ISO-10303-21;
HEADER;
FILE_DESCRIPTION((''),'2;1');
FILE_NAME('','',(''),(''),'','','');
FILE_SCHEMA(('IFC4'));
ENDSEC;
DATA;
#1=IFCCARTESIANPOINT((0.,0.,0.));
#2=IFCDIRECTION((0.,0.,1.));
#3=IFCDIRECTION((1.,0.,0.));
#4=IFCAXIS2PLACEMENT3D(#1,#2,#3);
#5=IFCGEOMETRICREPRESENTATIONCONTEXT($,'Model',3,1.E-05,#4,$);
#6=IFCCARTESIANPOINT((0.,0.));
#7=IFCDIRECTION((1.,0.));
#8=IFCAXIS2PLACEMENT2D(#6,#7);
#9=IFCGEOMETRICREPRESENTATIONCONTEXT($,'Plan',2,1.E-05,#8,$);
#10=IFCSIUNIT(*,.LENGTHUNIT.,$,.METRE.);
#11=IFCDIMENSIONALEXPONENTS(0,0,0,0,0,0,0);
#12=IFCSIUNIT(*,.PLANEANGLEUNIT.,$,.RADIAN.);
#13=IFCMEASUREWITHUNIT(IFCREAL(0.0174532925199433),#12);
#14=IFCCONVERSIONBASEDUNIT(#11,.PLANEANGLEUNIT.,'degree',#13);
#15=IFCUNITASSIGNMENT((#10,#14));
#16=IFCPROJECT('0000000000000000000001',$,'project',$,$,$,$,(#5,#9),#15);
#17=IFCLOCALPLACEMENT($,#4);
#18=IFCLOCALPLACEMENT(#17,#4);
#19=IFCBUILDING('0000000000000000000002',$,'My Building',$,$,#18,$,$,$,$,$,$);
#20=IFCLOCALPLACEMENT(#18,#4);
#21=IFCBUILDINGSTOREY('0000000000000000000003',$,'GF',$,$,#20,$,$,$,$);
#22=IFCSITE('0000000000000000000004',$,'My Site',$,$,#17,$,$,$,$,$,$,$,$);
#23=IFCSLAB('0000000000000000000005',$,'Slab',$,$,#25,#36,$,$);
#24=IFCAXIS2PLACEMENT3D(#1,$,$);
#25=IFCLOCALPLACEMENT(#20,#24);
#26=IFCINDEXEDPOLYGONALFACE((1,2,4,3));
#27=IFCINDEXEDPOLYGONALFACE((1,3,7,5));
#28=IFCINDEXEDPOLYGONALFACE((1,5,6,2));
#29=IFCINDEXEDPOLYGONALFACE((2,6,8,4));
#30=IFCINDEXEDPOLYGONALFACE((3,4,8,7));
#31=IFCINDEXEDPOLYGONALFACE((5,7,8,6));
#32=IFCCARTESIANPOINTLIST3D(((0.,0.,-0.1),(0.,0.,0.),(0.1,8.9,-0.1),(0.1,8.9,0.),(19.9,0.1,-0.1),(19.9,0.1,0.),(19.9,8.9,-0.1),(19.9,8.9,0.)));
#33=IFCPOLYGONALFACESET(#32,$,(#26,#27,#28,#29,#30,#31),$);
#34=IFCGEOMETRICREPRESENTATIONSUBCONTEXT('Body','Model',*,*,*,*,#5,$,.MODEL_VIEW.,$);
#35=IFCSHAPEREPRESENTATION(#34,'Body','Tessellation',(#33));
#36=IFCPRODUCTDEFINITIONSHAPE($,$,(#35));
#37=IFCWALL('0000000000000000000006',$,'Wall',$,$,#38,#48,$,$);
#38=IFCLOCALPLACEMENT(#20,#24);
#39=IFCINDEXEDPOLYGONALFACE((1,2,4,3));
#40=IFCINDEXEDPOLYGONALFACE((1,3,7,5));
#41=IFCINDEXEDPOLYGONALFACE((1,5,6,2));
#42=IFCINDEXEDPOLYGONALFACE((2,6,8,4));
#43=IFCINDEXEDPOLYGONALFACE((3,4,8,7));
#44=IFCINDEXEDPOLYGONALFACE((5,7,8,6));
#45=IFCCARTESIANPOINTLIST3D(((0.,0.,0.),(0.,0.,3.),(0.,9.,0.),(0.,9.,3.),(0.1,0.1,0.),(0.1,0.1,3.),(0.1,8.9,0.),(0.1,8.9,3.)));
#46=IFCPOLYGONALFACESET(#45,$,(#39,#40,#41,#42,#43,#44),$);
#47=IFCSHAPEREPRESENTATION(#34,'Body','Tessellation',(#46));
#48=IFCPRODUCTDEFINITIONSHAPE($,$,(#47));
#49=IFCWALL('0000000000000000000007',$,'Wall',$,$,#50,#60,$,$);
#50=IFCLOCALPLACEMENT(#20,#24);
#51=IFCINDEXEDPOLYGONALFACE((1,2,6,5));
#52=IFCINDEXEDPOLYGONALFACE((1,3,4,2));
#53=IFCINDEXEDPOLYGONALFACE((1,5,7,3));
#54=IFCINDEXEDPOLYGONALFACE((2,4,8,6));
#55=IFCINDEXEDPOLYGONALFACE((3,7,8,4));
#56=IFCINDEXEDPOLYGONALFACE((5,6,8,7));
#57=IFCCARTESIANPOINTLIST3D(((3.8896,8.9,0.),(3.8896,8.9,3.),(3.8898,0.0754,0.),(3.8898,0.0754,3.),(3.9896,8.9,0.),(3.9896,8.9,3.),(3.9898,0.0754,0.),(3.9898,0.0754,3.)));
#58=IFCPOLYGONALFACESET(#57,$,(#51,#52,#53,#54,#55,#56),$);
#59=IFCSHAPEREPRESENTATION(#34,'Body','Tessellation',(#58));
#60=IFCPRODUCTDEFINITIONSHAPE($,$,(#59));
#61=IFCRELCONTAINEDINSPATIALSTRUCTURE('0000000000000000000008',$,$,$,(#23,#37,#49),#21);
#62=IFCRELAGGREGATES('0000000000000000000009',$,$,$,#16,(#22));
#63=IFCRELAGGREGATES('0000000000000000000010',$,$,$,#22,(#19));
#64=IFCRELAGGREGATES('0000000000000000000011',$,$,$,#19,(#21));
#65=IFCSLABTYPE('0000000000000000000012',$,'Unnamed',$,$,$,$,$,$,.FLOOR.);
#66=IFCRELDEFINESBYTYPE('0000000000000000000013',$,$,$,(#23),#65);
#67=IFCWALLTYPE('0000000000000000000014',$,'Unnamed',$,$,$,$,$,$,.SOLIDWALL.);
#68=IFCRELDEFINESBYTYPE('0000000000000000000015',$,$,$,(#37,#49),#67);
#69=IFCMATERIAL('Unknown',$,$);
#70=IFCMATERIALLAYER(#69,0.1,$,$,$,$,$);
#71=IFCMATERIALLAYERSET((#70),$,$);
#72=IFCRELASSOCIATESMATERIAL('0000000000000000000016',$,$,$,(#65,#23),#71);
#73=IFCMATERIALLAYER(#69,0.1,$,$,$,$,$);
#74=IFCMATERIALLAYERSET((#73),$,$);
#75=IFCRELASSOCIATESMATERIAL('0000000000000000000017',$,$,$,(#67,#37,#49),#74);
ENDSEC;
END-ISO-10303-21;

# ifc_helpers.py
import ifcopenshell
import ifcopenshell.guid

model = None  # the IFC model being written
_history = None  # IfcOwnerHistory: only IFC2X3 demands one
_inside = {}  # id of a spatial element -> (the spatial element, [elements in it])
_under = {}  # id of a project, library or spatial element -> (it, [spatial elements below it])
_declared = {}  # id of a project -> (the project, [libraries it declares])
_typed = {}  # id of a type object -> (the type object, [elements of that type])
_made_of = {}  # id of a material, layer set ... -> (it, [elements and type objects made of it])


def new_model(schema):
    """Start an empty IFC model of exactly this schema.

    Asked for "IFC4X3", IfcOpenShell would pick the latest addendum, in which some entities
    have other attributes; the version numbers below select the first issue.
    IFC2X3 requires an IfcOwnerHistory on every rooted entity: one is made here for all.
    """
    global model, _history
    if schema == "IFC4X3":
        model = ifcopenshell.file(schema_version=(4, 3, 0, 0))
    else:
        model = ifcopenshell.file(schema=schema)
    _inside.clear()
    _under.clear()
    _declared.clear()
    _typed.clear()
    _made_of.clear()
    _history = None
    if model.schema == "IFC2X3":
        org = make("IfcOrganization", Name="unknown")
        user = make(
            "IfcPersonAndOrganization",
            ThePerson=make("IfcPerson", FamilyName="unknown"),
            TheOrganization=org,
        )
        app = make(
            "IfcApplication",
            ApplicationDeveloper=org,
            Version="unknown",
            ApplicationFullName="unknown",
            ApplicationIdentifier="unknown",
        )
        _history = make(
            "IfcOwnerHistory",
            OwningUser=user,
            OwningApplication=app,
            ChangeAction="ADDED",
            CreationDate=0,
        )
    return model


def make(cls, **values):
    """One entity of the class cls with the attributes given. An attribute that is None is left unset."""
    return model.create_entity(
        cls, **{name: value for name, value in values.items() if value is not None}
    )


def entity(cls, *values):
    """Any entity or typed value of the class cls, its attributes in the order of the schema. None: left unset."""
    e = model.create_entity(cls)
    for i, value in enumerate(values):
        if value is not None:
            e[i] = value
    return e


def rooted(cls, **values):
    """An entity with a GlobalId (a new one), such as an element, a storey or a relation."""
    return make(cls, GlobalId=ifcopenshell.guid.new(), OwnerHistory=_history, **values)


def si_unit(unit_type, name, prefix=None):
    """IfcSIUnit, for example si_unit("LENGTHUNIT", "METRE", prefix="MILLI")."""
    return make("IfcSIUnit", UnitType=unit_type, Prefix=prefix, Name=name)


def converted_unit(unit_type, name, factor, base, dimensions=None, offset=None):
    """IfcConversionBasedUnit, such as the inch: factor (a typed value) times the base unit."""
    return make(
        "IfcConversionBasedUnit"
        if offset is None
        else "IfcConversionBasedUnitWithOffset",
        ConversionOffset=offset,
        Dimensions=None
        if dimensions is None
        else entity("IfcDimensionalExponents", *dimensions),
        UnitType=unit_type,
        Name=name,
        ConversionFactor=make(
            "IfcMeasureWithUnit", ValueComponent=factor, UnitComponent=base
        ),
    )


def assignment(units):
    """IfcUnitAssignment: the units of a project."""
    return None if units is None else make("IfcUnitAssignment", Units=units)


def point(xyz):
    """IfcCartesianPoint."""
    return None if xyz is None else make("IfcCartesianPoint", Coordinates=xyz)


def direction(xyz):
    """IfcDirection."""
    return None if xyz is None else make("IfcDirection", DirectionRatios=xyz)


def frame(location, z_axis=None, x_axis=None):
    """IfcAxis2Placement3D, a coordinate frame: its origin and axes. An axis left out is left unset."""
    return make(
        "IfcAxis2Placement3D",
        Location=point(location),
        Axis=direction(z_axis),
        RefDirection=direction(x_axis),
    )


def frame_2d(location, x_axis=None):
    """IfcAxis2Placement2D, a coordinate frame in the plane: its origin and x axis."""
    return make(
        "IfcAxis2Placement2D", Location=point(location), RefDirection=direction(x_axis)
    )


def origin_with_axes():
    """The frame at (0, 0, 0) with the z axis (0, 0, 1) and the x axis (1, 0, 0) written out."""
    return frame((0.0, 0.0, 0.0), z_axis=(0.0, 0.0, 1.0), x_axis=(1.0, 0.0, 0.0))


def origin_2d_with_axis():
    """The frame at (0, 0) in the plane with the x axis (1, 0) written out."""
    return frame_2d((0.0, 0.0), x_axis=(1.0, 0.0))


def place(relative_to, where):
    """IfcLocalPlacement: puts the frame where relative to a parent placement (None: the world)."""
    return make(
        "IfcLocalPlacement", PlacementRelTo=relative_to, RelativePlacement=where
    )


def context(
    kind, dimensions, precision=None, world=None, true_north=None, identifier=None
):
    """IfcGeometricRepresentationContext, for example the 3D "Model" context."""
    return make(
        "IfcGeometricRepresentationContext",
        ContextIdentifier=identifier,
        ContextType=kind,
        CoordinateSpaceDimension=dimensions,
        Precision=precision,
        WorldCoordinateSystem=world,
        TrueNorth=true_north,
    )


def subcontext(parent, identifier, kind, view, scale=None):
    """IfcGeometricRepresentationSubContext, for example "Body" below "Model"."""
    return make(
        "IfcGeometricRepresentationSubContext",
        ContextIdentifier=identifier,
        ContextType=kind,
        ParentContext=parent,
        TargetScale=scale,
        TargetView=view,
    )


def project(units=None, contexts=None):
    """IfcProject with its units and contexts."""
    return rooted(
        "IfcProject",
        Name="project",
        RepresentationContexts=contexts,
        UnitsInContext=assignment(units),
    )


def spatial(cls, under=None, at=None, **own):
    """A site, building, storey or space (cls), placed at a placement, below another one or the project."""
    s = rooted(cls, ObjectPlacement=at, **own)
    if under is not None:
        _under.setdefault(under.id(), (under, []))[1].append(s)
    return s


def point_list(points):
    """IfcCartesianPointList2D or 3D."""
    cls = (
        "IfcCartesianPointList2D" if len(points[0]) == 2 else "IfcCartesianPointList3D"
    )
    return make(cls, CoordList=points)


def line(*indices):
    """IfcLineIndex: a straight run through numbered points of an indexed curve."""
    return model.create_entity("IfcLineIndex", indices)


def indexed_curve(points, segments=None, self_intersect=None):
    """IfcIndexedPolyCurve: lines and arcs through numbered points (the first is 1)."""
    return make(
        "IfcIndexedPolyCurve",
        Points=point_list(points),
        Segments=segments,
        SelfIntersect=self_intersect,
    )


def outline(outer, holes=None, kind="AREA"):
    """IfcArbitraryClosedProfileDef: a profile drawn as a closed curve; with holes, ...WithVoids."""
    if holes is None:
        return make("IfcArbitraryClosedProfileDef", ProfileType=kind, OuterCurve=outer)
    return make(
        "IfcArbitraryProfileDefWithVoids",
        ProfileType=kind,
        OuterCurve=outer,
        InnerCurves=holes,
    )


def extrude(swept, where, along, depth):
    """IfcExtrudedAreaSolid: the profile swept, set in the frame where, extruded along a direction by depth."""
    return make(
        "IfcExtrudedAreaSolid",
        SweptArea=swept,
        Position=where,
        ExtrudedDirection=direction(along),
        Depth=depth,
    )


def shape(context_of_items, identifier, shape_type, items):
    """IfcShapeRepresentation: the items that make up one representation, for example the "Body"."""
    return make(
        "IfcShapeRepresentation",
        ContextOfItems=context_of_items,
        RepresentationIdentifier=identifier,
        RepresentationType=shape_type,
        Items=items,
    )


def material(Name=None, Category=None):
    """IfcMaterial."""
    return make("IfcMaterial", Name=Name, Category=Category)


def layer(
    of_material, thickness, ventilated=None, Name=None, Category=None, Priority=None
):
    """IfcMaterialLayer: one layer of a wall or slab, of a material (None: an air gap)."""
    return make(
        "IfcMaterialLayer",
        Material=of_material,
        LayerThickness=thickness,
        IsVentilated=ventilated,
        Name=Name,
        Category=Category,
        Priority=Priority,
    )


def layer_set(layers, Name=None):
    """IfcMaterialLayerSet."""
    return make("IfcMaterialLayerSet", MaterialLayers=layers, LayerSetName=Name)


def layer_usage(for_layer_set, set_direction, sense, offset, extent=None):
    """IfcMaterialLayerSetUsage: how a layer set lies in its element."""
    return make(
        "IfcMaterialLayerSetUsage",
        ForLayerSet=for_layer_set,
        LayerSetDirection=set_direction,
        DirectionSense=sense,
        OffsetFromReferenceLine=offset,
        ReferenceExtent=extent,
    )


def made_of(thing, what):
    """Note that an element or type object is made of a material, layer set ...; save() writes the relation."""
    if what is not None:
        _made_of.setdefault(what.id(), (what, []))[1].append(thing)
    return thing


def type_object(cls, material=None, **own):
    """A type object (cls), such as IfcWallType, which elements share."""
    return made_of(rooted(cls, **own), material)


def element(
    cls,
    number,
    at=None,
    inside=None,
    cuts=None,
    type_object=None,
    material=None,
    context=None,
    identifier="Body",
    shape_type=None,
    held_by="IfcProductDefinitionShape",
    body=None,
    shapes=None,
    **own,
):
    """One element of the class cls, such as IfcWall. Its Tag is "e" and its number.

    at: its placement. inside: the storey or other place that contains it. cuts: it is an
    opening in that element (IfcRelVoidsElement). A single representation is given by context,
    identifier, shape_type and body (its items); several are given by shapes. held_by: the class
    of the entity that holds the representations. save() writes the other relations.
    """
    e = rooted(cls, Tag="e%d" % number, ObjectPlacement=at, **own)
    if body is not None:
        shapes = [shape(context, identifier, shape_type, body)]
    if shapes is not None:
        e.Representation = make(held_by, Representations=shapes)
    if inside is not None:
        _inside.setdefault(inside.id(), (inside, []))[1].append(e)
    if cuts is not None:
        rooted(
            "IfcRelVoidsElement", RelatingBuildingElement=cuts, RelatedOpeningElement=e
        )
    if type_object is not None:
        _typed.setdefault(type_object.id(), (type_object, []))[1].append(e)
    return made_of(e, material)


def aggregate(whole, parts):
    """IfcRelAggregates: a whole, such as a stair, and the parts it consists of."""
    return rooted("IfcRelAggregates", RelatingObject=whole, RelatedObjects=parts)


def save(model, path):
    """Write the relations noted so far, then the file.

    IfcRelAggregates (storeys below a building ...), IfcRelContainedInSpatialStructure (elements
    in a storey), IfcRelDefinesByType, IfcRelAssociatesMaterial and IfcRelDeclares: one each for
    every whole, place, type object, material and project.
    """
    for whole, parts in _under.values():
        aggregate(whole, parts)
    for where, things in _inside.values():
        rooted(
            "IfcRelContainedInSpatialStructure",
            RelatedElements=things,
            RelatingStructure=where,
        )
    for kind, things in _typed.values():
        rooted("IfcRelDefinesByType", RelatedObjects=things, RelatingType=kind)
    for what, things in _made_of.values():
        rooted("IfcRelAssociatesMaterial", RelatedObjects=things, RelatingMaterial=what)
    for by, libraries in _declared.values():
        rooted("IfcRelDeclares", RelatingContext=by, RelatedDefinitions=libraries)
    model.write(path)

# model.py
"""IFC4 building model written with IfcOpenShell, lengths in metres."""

from ifc_helpers import new_model, entity, si_unit, converted_unit, frame, origin_with_axes, origin_2d_with_axis, place, context, subcontext, project, spatial, line, indexed_curve, outline, extrude, material, layer, layer_set, layer_usage, type_object, element, save


model = new_model("IFC4")

# Units and contexts
model_context = context("Model", 3, precision=1e-05, world=origin_with_axes())
plan_context = context("Plan", 2, precision=1e-05, world=origin_2d_with_axis())
body_context_1 = subcontext(model_context, "Body", "Model", "MODEL_VIEW")
ifc_project = project(units=[si_unit("LENGTHUNIT", "METRE"), converted_unit("PLANEANGLEUNIT", "degree", entity("IfcReal", 0.0174532925199433), si_unit("PLANEANGLEUNIT", "RADIAN"), dimensions=[0, 0, 0, 0, 0, 0, 0])], contexts=[model_context, plan_context])

# Site, building, storey
site_placement = place(None, origin_with_axes())
site = spatial("IfcSite", under=ifc_project, at=site_placement, Name="My Site")
building_placement = place(site_placement, origin_with_axes())
building = spatial("IfcBuilding", under=site, at=building_placement, Name="My Building")
storey_placement = place(building_placement, origin_with_axes())
storey = spatial("IfcBuildingStorey", under=building, at=storey_placement, Name="GF")

# Slab
ifc_material = material(Name="Unknown")
ifc_layer_1 = layer(ifc_material, 0.1)
ifc_layer_set_1 = layer_set([ifc_layer_1])
ifc_layer_usage_1 = layer_usage(ifc_layer_set_1, "AXIS3", "POSITIVE", -0.1)
slab_type = type_object("IfcSlabType", Name="Unnamed", PredefinedType="FLOOR", material=ifc_layer_set_1)
slab_placement = place(storey_placement, frame((0.1, 8.9, 0.0), z_axis=(0.0, 0.0, 1.0), x_axis=(1.0, 0.0, 0.0)))
element("IfcSlab", 1, at=slab_placement, inside=storey, type_object=slab_type, material=ifc_layer_usage_1, Name="Slab", context=body_context_1, shape_type="SweptSolid", body=[
    extrude(outline(indexed_curve([(0.0, 0.0), (19.8, 0.0), (19.8, -8.8), (-0.1, -8.9), (0.0, 0.0)])), frame((0.0, 0.0, -0.1), z_axis=(0.0, 0.0, 1.0), x_axis=(1.0, 0.0, 0.0)), (0.0, 0.0, 1.0), 0.1),
])

# Shared definitions
ifc_layer_2 = layer(ifc_material, 0.1)
ifc_layer_set_2 = layer_set([ifc_layer_2])
wall_type = type_object("IfcWallType", Name="Unnamed", PredefinedType="SOLIDWALL", material=ifc_layer_set_2)

# Walls
ifc_layer_usage_2 = layer_usage(ifc_layer_set_2, "AXIS2", "POSITIVE", 0.0)
wall_1_placement = place(storey_placement, frame((0.0, 9.0, 0.0), z_axis=(0.0, 0.0, 1.0), x_axis=(0.0, -1.0, 0.0)))
element("IfcWall", 2, at=wall_1_placement, inside=storey, type_object=wall_type, material=ifc_layer_usage_2, Name="Wall", context=body_context_1, shape_type="SweptSolid", body=[
    extrude(outline(indexed_curve([(0.0, 0.0), (0.1, 0.1), (8.9, 0.1), (9.0, 0.0)], segments=[line(1, 2, 3, 4, 1)])), origin_with_axes(), (0.0, 0.0, 1.0), 3.0),
])
ifc_layer_usage_3 = layer_usage(ifc_layer_set_2, "AXIS2", "POSITIVE", 0.0)
wall_2_placement = place(storey_placement, frame((3.9898, 0.0754, 0.0), z_axis=(0.0, 0.0, 1.0), x_axis=(-0.000021, 1.0, 0.0)))
element("IfcWall", 3, at=wall_2_placement, inside=storey, type_object=wall_type, material=ifc_layer_usage_3, Name="Wall", context=body_context_1, shape_type="SweptSolid", body=[
    extrude(outline(indexed_curve([(0.0, 0.0), (0.0, 0.1), (8.8246, 0.1), (8.8246, 0.0)], segments=[line(1, 2, 3, 4, 1)])), origin_with_axes(), (0.0, 0.0, 1.0), 3.0),
])

save(model, "model.ifc")
